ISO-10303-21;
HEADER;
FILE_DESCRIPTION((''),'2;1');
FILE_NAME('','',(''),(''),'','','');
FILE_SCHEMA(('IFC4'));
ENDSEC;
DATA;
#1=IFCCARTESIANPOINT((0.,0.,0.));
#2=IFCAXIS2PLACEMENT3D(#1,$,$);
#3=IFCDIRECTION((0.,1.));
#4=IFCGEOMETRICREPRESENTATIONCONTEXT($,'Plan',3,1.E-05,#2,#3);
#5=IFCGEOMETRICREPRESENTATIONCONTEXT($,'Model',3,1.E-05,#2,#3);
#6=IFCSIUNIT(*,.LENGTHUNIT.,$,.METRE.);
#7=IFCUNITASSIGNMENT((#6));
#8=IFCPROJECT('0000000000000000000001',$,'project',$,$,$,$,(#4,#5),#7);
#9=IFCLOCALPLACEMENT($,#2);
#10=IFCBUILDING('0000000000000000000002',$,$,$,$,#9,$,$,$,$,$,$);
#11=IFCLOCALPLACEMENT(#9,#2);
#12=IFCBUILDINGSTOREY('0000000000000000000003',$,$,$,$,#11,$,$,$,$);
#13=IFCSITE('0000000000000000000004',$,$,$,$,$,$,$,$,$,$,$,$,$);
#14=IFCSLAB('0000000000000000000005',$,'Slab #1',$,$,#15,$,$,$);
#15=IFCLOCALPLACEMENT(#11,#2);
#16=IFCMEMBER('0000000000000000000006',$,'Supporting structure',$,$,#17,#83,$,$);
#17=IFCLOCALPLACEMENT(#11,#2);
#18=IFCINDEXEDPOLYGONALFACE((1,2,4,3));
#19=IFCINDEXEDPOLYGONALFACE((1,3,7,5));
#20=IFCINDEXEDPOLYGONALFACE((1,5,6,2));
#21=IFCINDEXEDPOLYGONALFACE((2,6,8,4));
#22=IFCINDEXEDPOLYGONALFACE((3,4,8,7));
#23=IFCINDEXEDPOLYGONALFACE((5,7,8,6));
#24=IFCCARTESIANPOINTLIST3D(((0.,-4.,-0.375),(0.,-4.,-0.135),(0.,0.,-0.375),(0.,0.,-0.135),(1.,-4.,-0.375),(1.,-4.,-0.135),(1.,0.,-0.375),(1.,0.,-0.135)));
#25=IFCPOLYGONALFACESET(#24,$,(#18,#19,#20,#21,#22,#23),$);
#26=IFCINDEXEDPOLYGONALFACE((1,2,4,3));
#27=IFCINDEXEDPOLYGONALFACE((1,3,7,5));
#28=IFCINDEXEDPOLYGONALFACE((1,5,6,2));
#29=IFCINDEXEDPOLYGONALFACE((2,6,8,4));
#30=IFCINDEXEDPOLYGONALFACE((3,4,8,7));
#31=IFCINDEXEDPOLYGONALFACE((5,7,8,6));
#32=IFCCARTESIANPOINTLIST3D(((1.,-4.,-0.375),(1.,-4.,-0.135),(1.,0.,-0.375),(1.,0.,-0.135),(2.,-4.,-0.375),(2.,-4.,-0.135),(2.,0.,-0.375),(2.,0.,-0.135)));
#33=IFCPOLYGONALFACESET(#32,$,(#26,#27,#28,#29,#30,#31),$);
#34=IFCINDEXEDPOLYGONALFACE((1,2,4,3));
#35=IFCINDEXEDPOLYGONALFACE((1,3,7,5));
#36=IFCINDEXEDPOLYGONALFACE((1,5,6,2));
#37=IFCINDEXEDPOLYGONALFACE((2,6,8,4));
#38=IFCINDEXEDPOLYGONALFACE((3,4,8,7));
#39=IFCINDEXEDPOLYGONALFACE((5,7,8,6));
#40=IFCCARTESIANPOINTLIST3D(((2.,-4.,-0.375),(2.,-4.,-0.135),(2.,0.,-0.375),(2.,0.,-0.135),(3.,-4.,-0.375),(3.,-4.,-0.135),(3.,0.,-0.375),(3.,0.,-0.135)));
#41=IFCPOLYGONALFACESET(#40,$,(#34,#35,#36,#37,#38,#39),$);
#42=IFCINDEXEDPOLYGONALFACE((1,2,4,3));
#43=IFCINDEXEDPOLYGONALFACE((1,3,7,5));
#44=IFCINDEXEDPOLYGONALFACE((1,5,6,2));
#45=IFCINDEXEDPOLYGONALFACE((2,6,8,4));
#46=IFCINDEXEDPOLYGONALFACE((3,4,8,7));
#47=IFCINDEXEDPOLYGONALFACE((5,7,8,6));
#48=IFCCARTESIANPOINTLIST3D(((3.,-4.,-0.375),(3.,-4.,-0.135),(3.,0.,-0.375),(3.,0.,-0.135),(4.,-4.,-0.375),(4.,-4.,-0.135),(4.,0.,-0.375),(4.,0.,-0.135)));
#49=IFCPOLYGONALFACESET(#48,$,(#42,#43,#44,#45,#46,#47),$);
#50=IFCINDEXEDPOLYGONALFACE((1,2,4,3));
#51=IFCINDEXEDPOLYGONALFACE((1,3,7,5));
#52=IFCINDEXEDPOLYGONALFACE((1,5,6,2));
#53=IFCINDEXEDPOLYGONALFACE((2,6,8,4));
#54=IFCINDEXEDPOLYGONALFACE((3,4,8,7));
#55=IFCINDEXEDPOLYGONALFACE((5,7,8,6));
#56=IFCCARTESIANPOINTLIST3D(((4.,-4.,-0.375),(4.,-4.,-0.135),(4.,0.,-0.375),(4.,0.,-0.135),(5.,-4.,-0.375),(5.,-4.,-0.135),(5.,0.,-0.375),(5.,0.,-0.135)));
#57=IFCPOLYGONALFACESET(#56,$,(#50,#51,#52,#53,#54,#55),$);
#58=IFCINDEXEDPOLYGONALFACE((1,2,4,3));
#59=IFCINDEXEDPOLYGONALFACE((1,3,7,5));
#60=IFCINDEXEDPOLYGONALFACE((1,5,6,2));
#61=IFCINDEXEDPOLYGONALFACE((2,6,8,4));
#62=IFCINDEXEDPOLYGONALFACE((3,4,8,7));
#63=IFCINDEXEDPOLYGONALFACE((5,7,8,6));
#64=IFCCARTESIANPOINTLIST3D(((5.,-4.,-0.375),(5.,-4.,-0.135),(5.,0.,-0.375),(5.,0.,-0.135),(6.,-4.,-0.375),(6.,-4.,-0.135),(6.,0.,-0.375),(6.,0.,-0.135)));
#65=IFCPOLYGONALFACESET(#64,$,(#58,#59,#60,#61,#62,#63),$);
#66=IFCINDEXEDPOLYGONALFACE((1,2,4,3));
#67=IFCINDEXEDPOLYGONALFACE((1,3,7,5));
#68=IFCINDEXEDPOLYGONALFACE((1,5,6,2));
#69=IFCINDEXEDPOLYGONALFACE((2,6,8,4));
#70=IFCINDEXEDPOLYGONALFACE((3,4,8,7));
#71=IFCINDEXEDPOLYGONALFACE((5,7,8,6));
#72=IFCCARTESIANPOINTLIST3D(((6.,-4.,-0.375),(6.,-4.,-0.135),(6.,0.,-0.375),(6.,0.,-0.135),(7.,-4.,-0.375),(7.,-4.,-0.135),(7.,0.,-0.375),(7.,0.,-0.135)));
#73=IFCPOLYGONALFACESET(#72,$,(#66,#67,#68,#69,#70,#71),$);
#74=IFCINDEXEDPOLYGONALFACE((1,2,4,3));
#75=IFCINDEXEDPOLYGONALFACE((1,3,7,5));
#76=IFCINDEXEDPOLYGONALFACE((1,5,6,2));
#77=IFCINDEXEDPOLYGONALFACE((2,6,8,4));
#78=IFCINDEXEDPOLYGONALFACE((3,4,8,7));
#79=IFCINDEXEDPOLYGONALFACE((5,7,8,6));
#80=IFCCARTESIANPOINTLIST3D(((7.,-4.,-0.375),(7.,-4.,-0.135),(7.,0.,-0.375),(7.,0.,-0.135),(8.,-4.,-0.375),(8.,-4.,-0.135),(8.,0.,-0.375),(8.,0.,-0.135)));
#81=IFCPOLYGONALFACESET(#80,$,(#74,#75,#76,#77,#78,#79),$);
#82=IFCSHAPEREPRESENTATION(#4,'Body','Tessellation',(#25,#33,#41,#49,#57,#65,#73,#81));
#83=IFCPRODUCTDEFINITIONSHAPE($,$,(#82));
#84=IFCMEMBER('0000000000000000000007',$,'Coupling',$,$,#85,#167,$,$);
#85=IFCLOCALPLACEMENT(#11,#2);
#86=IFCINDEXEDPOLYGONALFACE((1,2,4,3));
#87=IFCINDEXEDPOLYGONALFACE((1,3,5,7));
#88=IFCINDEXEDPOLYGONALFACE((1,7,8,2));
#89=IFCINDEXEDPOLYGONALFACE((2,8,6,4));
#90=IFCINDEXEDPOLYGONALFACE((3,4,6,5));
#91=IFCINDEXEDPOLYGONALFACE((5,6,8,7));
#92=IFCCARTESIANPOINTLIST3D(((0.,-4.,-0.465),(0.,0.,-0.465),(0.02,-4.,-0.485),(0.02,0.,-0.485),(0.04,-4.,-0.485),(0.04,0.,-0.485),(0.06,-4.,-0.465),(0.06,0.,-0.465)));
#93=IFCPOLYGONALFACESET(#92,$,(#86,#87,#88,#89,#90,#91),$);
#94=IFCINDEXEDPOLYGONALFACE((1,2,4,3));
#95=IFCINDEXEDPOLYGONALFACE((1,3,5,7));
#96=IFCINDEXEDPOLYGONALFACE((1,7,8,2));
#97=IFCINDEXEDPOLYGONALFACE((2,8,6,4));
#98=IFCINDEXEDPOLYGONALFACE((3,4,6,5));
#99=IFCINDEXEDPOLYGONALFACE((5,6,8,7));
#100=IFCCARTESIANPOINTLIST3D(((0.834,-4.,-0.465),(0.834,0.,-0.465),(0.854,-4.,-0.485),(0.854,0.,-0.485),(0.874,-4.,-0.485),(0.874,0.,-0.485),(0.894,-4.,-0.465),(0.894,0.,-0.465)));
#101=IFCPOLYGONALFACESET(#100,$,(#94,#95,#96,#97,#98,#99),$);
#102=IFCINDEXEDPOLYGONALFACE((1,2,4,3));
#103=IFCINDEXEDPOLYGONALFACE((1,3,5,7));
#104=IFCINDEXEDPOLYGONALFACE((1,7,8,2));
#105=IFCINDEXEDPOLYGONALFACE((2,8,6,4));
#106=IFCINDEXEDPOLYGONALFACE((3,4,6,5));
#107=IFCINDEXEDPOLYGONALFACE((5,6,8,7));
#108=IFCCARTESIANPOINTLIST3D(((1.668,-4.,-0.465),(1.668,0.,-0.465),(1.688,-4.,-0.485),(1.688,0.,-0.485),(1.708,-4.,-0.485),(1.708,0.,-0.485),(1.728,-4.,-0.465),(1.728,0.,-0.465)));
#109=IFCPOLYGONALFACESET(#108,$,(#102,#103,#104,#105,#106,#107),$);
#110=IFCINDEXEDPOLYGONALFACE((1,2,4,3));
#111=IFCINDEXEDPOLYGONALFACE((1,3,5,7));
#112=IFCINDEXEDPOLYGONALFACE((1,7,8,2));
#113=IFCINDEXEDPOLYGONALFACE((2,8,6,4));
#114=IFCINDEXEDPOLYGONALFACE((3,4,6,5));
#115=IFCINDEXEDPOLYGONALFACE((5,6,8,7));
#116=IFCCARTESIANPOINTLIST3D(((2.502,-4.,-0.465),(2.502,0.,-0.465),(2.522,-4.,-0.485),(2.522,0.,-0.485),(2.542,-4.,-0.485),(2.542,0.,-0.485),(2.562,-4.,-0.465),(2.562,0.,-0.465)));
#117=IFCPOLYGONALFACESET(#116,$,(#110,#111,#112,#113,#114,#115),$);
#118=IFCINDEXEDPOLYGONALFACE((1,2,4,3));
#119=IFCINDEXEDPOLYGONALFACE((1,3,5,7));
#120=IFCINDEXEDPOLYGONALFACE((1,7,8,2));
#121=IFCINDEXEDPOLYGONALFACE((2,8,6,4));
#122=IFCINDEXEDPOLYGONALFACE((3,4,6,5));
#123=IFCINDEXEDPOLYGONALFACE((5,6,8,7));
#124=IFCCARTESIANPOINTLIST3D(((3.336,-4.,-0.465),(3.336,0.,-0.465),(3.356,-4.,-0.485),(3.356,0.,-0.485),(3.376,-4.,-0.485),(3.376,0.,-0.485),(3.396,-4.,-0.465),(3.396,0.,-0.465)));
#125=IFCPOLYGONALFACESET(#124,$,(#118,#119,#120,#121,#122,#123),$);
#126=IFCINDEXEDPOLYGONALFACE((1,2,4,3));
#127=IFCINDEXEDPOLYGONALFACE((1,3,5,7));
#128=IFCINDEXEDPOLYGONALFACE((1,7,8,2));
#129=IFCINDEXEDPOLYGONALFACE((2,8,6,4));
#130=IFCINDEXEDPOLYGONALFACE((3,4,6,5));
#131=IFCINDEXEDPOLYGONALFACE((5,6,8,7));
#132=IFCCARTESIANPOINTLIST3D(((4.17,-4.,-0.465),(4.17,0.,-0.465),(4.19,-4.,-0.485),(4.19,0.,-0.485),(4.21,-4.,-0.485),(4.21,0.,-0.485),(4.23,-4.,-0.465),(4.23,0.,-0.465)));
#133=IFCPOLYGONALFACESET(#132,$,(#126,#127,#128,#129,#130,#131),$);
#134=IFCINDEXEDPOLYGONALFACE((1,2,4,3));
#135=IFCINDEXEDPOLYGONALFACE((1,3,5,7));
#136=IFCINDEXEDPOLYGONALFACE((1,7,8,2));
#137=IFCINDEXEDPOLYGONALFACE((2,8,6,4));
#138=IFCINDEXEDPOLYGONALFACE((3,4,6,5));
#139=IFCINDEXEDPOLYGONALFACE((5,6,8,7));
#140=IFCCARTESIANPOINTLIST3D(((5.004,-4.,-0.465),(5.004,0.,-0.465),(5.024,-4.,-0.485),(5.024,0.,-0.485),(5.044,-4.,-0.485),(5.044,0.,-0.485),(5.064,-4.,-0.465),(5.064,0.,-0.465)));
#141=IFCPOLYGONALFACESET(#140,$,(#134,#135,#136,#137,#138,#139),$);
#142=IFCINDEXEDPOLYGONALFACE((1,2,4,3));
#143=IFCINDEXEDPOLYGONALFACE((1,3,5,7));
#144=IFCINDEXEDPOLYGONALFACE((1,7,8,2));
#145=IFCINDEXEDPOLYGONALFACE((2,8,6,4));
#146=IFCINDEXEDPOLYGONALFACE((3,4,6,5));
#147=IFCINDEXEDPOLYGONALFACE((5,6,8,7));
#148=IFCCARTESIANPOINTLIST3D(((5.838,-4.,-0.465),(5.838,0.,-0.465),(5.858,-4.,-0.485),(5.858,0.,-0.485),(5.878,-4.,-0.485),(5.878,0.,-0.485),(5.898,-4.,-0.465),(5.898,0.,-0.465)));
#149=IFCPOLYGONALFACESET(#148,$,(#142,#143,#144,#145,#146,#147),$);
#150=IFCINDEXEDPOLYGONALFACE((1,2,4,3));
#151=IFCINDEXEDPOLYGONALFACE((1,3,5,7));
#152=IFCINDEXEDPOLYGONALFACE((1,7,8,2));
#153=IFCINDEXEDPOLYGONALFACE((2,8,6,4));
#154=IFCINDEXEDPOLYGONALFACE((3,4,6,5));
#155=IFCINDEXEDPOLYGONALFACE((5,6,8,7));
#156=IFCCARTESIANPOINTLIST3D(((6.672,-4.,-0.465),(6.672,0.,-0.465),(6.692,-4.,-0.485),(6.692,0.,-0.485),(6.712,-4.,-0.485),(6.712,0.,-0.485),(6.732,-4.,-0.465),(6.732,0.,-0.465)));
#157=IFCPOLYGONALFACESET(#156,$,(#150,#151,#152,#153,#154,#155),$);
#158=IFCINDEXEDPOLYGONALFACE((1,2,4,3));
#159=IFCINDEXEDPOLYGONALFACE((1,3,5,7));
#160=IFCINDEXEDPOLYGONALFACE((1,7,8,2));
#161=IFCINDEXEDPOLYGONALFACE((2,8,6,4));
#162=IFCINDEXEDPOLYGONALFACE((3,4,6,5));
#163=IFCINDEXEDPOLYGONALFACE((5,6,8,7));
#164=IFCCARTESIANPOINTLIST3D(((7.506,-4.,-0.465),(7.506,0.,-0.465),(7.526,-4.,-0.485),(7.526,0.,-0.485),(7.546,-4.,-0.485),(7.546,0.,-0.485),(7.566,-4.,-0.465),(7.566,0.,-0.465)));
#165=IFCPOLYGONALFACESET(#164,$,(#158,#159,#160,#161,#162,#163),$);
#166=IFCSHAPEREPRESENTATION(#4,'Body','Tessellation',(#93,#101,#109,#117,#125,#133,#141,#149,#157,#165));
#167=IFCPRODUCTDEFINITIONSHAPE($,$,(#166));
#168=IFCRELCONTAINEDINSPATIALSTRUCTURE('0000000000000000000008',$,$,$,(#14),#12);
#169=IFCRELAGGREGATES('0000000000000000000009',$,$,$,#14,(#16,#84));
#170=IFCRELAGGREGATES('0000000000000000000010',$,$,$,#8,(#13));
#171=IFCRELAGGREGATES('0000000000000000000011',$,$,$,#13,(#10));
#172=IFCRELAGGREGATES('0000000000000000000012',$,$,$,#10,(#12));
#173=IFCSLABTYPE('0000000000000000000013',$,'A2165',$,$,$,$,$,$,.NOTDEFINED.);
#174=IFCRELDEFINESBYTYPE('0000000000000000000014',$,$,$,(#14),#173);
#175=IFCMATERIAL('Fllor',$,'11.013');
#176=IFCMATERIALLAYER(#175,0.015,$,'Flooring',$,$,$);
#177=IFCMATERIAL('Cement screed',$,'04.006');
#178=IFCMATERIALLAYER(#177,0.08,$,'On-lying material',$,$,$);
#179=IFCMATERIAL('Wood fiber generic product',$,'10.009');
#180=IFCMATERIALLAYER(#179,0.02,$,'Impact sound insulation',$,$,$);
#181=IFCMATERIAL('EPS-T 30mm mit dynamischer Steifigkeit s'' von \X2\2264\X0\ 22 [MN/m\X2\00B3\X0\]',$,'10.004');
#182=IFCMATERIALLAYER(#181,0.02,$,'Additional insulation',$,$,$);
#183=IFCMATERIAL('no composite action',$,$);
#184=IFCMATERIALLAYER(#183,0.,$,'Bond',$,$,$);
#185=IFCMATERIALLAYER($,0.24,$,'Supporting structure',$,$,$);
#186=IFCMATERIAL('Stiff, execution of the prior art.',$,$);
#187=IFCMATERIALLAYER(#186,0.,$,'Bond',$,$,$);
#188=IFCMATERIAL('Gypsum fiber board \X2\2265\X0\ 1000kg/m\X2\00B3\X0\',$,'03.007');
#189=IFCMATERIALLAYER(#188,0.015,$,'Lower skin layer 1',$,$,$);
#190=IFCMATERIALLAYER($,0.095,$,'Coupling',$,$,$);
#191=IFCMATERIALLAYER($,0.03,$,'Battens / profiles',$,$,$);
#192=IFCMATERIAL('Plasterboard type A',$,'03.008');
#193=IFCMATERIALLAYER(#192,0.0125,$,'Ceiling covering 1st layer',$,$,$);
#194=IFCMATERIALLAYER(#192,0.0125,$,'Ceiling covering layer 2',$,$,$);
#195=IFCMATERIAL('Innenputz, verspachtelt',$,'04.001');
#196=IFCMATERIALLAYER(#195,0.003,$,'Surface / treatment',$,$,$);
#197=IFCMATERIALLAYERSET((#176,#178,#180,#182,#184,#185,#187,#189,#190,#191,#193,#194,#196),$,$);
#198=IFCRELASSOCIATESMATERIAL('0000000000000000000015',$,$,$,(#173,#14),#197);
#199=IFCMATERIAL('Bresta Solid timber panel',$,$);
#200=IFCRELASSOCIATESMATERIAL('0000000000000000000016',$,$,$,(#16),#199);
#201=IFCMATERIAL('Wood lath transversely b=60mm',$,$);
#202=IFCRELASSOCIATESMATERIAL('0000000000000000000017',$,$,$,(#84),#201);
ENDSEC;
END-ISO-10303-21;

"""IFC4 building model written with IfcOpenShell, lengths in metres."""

from ifc_helpers import new_model, si_unit, direction, frame, frame_2d, origin, place, context, project, spatial, polyline, rectangle, outline, extrude, material, layer, layer_set, type_object, element, aggregate, save


model = new_model("IFC4")

# Units and contexts
plan_context = context("Plan", 3, precision=1e-05, world=origin(), true_north=direction((0.0, 1.0)))
model_context = context("Model", 3, precision=1e-05, world=origin(), true_north=direction((0.0, 1.0)))
ifc_project = project(units=[si_unit("LENGTHUNIT", "METRE")], contexts=[plan_context, model_context])

# Site, building, storey
site = spatial("IfcSite", under=ifc_project)
building_placement = place(None, origin())
building = spatial("IfcBuilding", under=site, at=building_placement)
storey_placement = place(building_placement, origin())
storey = spatial("IfcBuildingStorey", under=building, at=storey_placement)

# Slab, members
ifc_material_1 = material(Name="Fllor", Category="11.013")
ifc_layer_1 = layer(ifc_material_1, 0.015, Name="Flooring")
ifc_material_2 = material(Name="Cement screed", Category="04.006")
ifc_layer_2 = layer(ifc_material_2, 0.08, Name="On-lying material")
ifc_material_3 = material(Name="Wood fiber generic product", Category="10.009")
ifc_layer_3 = layer(ifc_material_3, 0.02, Name="Impact sound insulation")
ifc_material_4 = material(Name="EPS-T 30mm mit dynamischer Steifigkeit s' von ≤ 22 [MN/m³]", Category="10.004")
ifc_layer_4 = layer(ifc_material_4, 0.02, Name="Additional insulation")
ifc_material_5 = material(Name="no composite action")
ifc_layer_5 = layer(ifc_material_5, 0.0, Name="Bond")
ifc_layer_6 = layer(None, 0.24, Name="Supporting structure")
ifc_material_6 = material(Name="Stiff, execution of the prior art.")
ifc_layer_7 = layer(ifc_material_6, 0.0, Name="Bond")
ifc_material_7 = material(Name="Gypsum fiber board ≥ 1000kg/m³", Category="03.007")
ifc_layer_8 = layer(ifc_material_7, 0.015, Name="Lower skin layer 1")
ifc_layer_9 = layer(None, 0.095, Name="Coupling")
ifc_layer_10 = layer(None, 0.03, Name="Battens / profiles")
ifc_material_8 = material(Name="Plasterboard type A", Category="03.008")
ifc_layer_11 = layer(ifc_material_8, 0.0125, Name="Ceiling covering 1st layer")
ifc_layer_12 = layer(ifc_material_8, 0.0125, Name="Ceiling covering layer 2")
ifc_material_9 = material(Name="Innenputz, verspachtelt", Category="04.001")
ifc_layer_13 = layer(ifc_material_9, 0.003, Name="Surface / treatment")
ifc_layer_set = layer_set([ifc_layer_1, ifc_layer_2, ifc_layer_3, ifc_layer_4, ifc_layer_5, ifc_layer_6, ifc_layer_7, ifc_layer_8, ifc_layer_9, ifc_layer_10, ifc_layer_11, ifc_layer_12, ifc_layer_13])
slab_type = type_object("IfcSlabType", Name="A2165", PredefinedType="NOTDEFINED", material=ifc_layer_set)
slab_placement = place(None, frame((0.0, 0.0, 0.0), z_axis=(0.0, 0.0, -1.0), x_axis=(1.0, 0.0, 0.0)))
slab = element("IfcSlab", 1, at=slab_placement, inside=storey, type_object=slab_type, material=ifc_layer_set, Name="Slab #1")
ifc_material_10 = material(Name="Bresta Solid timber panel")
member_1_placement = place(slab_placement, origin())
member_1 = element("IfcMember", 2, at=member_1_placement, material=ifc_material_10, Name="Supporting structure", context=plan_context, shape_type="SweptSolid", body=[
    extrude(rectangle(XDim=1.0, YDim=0.24, at=frame_2d((0.5, 0.12), x_axis=(1.0, 0.0))), frame((0.0, 4.0, 0.135), z_axis=(0.0, -1.0, 0.0), x_axis=(1.0, 0.0, 0.0)), (0.0, 0.0, 1.0), 4.0),
    extrude(rectangle(XDim=1.0, YDim=0.24, at=frame_2d((0.5, 0.12), x_axis=(1.0, 0.0))), frame((1.0, 4.0, 0.135), z_axis=(0.0, -1.0, 0.0), x_axis=(1.0, 0.0, 0.0)), (0.0, 0.0, 1.0), 4.0),
    extrude(rectangle(XDim=1.0, YDim=0.24, at=frame_2d((0.5, 0.12), x_axis=(1.0, 0.0))), frame((2.0, 4.0, 0.135), z_axis=(0.0, -1.0, 0.0), x_axis=(1.0, 0.0, 0.0)), (0.0, 0.0, 1.0), 4.0),
    extrude(rectangle(XDim=1.0, YDim=0.24, at=frame_2d((0.5, 0.12), x_axis=(1.0, 0.0))), frame((3.0, 4.0, 0.135), z_axis=(0.0, -1.0, 0.0), x_axis=(1.0, 0.0, 0.0)), (0.0, 0.0, 1.0), 4.0),
    extrude(rectangle(XDim=1.0, YDim=0.24, at=frame_2d((0.5, 0.12), x_axis=(1.0, 0.0))), frame((4.0, 4.0, 0.135), z_axis=(0.0, -1.0, 0.0), x_axis=(1.0, 0.0, 0.0)), (0.0, 0.0, 1.0), 4.0),
    extrude(rectangle(XDim=1.0, YDim=0.24, at=frame_2d((0.5, 0.12), x_axis=(1.0, 0.0))), frame((5.0, 4.0, 0.135), z_axis=(0.0, -1.0, 0.0), x_axis=(1.0, 0.0, 0.0)), (0.0, 0.0, 1.0), 4.0),
    extrude(rectangle(XDim=1.0, YDim=0.24, at=frame_2d((0.5, 0.12), x_axis=(1.0, 0.0))), frame((6.0, 4.0, 0.135), z_axis=(0.0, -1.0, 0.0), x_axis=(1.0, 0.0, 0.0)), (0.0, 0.0, 1.0), 4.0),
    extrude(rectangle(XDim=1.0, YDim=0.24, at=frame_2d((0.5, 0.12), x_axis=(1.0, 0.0))), frame((7.0, 4.0, 0.135), z_axis=(0.0, -1.0, 0.0), x_axis=(1.0, 0.0, 0.0)), (0.0, 0.0, 1.0), 4.0),
])
ifc_material_11 = material(Name="Wood lath transversely b=60mm")
member_2_placement = place(slab_placement, origin())
member_2 = element("IfcMember", 3, at=member_2_placement, material=ifc_material_11, Name="Coupling", context=plan_context, shape_type="SweptSolid", body=[
    extrude(outline(polyline([(0.0, 0.0), (0.06, 0.0), (0.04, 0.02), (0.02, 0.02), (0.0, 0.0)])), frame((0.0, 4.0, 0.465), z_axis=(0.0, -1.0, 0.0), x_axis=(1.0, 0.0, 0.0)), (0.0, 0.0, 1.0), 4.0),
    extrude(outline(polyline([(0.0, 0.0), (0.06, 0.0), (0.04, 0.02), (0.02, 0.02), (0.0, 0.0)])), frame((0.834, 4.0, 0.465), z_axis=(0.0, -1.0, 0.0), x_axis=(1.0, 0.0, 0.0)), (0.0, 0.0, 1.0), 4.0),
    extrude(outline(polyline([(0.0, 0.0), (0.06, 0.0), (0.04, 0.02), (0.02, 0.02), (0.0, 0.0)])), frame((1.668, 4.0, 0.465), z_axis=(0.0, -1.0, 0.0), x_axis=(1.0, 0.0, 0.0)), (0.0, 0.0, 1.0), 4.0),
    extrude(outline(polyline([(0.0, 0.0), (0.06, 0.0), (0.04, 0.02), (0.02, 0.02), (0.0, 0.0)])), frame((2.502, 4.0, 0.465), z_axis=(0.0, -1.0, 0.0), x_axis=(1.0, 0.0, 0.0)), (0.0, 0.0, 1.0), 4.0),
    extrude(outline(polyline([(0.0, 0.0), (0.06, 0.0), (0.04, 0.02), (0.02, 0.02), (0.0, 0.0)])), frame((3.336, 4.0, 0.465), z_axis=(0.0, -1.0, 0.0), x_axis=(1.0, 0.0, 0.0)), (0.0, 0.0, 1.0), 4.0),
    extrude(outline(polyline([(0.0, 0.0), (0.06, 0.0), (0.04, 0.02), (0.02, 0.02), (0.0, 0.0)])), frame((4.17, 4.0, 0.465), z_axis=(0.0, -1.0, 0.0), x_axis=(1.0, 0.0, 0.0)), (0.0, 0.0, 1.0), 4.0),
    extrude(outline(polyline([(0.0, 0.0), (0.06, 0.0), (0.04, 0.02), (0.02, 0.02), (0.0, 0.0)])), frame((5.004, 4.0, 0.465), z_axis=(0.0, -1.0, 0.0), x_axis=(1.0, 0.0, 0.0)), (0.0, 0.0, 1.0), 4.0),
    extrude(outline(polyline([(0.0, 0.0), (0.06, 0.0), (0.04, 0.02), (0.02, 0.02), (0.0, 0.0)])), frame((5.838, 4.0, 0.465), z_axis=(0.0, -1.0, 0.0), x_axis=(1.0, 0.0, 0.0)), (0.0, 0.0, 1.0), 4.0),
    extrude(outline(polyline([(0.0, 0.0), (0.06, 0.0), (0.04, 0.02), (0.02, 0.02), (0.0, 0.0)])), frame((6.672, 4.0, 0.465), z_axis=(0.0, -1.0, 0.0), x_axis=(1.0, 0.0, 0.0)), (0.0, 0.0, 1.0), 4.0),
    extrude(outline(polyline([(0.0, 0.0), (0.06, 0.0), (0.04, 0.02), (0.02, 0.02), (0.0, 0.0)])), frame((7.506, 4.0, 0.465), z_axis=(0.0, -1.0, 0.0), x_axis=(1.0, 0.0, 0.0)), (0.0, 0.0, 1.0), 4.0),
])
aggregate(slab, [member_1, member_2])

save(model, "model.ifc")
